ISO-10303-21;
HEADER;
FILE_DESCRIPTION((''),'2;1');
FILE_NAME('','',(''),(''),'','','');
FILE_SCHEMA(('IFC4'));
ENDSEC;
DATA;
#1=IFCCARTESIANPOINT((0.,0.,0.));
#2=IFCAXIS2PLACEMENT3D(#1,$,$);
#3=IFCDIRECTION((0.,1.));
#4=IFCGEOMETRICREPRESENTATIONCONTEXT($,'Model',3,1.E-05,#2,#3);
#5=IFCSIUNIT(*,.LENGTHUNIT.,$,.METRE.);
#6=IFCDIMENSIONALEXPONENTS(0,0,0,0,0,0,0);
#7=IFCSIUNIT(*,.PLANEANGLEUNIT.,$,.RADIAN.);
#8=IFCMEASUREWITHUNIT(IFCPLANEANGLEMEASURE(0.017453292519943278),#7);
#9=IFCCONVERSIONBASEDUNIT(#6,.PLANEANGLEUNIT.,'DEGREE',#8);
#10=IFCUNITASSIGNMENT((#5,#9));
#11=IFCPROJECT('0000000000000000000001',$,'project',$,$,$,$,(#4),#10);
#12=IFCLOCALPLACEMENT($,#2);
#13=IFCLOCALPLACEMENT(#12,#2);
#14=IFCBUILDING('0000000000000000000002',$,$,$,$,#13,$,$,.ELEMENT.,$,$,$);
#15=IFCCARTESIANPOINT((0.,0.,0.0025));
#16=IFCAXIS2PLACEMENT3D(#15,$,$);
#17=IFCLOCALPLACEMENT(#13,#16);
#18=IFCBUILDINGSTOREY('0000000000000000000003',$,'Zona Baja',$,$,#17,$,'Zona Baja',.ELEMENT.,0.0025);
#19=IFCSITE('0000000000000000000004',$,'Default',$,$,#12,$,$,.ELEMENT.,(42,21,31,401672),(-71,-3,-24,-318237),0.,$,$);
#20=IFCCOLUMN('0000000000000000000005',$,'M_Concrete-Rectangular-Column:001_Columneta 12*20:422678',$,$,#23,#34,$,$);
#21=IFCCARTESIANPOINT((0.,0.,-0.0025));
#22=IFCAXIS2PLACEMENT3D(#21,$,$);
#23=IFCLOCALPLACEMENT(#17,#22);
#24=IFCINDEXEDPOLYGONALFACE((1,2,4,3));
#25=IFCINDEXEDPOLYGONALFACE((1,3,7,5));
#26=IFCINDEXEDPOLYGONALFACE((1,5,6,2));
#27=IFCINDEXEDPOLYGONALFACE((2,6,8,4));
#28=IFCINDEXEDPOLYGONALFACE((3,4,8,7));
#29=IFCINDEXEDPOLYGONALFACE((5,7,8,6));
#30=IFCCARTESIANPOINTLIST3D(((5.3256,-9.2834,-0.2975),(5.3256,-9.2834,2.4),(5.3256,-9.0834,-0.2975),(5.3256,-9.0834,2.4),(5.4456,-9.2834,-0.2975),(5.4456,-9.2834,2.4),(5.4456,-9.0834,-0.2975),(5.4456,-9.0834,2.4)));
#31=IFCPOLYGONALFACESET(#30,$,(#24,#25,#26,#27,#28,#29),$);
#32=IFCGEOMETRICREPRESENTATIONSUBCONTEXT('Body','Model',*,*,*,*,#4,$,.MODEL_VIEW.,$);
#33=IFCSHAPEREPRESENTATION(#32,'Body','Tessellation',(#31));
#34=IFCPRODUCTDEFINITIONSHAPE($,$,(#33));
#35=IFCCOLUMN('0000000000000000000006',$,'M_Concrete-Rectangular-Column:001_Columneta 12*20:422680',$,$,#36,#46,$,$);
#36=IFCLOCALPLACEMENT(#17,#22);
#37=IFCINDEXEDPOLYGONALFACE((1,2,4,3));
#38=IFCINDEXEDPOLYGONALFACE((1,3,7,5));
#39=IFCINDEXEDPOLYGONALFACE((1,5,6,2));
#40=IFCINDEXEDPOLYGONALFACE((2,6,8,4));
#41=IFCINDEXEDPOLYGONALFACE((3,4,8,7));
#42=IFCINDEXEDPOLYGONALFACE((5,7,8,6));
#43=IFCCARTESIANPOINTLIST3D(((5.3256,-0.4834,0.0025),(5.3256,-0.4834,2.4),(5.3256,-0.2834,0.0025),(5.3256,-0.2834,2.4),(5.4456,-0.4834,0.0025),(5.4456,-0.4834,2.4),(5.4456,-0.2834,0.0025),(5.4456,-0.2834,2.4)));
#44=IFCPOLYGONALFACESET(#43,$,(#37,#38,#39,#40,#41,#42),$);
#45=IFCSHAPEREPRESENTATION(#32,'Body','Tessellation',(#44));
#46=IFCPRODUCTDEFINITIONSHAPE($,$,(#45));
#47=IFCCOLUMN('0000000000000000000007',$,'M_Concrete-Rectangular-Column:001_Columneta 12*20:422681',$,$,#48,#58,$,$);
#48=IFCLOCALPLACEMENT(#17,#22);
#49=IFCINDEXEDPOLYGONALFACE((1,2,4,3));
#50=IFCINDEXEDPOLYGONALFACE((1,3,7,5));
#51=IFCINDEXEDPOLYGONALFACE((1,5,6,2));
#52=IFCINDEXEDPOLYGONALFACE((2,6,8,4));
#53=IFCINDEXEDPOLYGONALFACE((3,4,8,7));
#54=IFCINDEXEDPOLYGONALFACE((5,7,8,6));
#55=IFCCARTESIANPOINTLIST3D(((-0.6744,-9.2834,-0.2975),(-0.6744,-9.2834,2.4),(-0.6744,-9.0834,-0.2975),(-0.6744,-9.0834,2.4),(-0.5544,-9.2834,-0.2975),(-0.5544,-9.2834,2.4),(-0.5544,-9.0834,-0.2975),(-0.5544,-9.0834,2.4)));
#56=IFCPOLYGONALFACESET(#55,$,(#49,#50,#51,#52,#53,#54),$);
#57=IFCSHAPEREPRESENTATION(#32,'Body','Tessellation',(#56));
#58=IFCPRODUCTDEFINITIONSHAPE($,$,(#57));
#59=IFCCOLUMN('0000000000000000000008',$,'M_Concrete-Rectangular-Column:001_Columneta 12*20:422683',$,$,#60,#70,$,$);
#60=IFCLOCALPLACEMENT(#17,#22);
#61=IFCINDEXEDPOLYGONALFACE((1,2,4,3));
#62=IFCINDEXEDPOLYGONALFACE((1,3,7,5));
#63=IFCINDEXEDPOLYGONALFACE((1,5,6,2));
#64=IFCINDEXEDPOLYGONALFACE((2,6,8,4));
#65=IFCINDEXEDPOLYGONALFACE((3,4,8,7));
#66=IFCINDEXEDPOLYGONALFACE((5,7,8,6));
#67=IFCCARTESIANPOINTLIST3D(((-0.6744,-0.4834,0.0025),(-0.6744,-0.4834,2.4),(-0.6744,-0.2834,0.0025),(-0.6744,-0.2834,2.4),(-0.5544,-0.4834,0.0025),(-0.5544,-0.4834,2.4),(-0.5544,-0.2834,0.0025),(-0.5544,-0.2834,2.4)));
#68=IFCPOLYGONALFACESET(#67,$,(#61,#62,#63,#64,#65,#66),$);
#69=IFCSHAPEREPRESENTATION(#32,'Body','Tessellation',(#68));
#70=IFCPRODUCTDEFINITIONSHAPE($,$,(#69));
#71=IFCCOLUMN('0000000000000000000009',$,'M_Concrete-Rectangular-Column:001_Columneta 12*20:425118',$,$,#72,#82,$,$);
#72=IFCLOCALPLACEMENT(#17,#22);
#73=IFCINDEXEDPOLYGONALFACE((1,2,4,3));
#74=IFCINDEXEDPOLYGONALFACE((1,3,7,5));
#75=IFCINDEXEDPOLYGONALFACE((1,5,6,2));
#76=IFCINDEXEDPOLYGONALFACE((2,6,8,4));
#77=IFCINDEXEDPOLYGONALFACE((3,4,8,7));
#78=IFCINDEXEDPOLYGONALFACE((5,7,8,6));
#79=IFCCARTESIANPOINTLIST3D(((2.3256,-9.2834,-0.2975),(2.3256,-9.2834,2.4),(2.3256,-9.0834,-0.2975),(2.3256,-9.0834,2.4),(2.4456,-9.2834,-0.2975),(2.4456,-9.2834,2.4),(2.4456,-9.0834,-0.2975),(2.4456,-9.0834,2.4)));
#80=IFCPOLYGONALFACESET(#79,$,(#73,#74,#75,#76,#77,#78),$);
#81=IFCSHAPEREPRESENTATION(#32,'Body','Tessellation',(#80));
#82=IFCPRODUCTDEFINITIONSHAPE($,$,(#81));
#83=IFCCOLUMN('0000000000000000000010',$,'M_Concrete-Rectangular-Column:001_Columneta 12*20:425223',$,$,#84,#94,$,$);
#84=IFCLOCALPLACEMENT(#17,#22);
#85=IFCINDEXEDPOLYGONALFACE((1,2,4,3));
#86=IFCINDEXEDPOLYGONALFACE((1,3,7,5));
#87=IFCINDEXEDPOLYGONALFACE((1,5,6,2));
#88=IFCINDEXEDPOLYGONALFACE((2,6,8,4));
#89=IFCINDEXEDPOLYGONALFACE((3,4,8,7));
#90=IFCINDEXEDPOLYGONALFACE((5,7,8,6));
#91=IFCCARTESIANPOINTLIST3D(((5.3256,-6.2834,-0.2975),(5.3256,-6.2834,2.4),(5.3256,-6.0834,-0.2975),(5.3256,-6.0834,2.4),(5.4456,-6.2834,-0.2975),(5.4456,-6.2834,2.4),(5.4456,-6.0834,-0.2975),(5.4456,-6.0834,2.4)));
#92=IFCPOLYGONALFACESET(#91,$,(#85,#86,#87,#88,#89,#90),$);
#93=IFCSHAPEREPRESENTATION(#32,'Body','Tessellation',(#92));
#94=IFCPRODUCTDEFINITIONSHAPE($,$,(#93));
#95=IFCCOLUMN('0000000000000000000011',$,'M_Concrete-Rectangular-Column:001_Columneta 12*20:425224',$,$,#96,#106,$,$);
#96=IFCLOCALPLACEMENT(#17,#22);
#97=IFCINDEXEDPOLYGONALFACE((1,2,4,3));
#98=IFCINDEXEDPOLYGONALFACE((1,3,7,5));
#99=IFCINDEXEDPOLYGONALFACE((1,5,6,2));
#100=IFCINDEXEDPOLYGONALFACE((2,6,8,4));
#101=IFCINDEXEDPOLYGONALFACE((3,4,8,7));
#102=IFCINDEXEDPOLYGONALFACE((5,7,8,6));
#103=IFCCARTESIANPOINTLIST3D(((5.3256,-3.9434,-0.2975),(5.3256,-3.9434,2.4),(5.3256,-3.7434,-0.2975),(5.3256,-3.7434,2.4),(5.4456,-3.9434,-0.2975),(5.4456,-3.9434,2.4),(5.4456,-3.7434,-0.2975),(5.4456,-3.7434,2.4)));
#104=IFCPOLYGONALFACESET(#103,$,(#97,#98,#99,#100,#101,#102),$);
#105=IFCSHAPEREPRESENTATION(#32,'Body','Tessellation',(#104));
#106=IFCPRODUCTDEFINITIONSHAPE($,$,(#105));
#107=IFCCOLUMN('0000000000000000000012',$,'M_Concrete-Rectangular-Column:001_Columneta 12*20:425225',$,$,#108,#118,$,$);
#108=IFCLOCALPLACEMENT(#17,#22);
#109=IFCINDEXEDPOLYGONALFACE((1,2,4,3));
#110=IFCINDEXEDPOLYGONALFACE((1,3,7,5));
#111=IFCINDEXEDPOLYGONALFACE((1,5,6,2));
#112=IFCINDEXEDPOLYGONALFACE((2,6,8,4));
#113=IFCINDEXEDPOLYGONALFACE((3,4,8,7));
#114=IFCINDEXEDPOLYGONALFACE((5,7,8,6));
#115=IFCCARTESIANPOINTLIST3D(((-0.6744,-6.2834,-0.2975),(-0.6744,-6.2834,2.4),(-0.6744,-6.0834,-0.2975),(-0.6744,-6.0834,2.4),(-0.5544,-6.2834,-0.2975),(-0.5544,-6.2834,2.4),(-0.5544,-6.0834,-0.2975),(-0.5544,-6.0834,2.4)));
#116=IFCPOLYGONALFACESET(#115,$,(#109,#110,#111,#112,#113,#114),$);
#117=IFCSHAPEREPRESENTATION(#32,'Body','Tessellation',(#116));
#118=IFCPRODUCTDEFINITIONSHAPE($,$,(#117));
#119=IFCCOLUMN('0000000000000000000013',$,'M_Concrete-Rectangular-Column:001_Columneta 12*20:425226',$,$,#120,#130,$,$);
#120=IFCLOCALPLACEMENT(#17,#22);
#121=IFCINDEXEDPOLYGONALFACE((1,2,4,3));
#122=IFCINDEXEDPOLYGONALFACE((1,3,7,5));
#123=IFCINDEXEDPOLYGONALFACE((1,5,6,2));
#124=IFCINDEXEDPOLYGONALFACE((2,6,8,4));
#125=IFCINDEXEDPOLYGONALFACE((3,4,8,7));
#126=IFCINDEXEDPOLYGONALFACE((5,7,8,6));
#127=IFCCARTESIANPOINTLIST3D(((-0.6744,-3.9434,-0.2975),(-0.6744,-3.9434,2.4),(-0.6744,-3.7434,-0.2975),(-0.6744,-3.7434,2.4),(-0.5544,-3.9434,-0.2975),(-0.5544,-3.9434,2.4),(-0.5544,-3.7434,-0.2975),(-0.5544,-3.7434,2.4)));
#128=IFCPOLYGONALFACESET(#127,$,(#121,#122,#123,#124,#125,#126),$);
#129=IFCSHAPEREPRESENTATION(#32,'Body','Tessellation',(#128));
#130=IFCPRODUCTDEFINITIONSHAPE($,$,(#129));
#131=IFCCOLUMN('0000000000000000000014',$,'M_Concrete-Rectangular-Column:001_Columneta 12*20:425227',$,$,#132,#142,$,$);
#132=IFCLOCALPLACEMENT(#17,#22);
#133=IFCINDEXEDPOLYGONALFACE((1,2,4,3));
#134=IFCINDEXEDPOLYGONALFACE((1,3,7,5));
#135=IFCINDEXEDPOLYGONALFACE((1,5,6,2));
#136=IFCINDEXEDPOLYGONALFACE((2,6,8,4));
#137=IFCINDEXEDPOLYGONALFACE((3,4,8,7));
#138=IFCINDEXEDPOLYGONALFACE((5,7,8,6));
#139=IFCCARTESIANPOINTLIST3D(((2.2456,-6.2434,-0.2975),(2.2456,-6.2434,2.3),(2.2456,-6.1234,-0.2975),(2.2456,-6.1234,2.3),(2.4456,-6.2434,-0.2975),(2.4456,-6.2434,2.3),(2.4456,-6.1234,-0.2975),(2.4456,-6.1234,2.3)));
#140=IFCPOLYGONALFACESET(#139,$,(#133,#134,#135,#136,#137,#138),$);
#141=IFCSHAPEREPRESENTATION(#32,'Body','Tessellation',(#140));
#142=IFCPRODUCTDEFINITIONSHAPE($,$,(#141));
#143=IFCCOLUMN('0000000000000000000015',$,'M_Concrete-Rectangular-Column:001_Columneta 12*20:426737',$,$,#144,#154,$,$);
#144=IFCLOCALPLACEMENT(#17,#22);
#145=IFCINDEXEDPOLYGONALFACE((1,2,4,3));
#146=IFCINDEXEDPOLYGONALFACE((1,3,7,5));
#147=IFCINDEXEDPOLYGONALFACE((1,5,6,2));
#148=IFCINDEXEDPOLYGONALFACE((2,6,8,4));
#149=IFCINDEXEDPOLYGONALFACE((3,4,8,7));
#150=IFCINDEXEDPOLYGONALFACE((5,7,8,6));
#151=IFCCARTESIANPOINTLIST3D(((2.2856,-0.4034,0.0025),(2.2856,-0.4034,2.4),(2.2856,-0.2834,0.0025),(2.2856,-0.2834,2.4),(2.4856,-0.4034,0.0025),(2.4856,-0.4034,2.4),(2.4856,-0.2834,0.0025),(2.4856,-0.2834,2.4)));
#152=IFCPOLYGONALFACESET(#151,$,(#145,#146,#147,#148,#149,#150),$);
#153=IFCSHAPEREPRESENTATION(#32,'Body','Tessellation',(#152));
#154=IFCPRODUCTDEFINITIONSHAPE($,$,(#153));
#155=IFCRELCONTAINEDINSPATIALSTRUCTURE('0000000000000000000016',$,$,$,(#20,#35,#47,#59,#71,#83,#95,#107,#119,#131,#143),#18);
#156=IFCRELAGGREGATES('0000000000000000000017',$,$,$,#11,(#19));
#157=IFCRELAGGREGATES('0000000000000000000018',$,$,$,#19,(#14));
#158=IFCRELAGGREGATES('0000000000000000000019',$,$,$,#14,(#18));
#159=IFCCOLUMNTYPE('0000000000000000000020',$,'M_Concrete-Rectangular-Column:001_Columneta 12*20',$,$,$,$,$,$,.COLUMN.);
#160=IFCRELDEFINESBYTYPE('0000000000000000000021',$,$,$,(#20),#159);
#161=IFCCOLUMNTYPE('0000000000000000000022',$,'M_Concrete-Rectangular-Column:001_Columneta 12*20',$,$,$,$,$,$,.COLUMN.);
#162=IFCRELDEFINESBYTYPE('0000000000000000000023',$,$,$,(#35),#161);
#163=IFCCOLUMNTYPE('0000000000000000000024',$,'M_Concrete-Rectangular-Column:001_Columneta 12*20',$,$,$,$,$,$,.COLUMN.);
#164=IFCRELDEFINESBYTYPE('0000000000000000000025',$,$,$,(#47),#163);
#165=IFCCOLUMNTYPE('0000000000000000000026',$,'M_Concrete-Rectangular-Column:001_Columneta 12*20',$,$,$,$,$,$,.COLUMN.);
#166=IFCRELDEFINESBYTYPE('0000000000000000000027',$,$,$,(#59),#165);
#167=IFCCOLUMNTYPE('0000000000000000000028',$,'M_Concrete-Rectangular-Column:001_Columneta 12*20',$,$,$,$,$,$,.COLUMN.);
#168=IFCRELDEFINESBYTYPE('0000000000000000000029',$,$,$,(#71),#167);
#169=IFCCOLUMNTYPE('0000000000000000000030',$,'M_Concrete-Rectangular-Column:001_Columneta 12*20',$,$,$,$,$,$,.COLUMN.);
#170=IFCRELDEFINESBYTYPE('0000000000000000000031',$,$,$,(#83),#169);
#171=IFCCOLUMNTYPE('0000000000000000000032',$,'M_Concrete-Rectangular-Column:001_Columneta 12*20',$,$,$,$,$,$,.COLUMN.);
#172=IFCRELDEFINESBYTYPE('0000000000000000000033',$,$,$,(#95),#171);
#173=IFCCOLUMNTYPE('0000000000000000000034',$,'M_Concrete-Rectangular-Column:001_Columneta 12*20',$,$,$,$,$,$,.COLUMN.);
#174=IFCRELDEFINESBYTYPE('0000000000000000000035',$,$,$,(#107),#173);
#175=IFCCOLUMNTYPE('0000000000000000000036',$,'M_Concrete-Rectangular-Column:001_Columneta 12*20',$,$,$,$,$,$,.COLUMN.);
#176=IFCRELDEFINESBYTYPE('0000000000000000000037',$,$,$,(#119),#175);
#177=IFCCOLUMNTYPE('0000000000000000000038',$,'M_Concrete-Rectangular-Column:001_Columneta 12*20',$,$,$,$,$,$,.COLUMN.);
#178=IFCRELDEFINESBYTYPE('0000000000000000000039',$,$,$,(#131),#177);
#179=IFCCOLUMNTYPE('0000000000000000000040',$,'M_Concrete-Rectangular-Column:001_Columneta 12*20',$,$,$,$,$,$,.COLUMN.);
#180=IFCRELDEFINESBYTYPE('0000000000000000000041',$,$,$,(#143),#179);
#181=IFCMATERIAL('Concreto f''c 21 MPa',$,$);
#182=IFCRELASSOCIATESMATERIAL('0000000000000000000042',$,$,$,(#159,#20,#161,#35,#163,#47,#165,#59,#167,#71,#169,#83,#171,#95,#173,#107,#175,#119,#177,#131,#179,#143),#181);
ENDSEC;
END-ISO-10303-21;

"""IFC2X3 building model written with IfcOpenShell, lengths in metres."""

from ifc_helpers import new_model, entity, si_unit, converted_unit, direction, frame, frame_2d, origin, origin_2d_with_axis, place, context, subcontext, project, spatial, rectangle, extrude, source, transform, mapped, material, type_object, type_shapes, element, save


model = new_model("IFC2X3")

# Units and contexts
model_context = context("Model", 3, precision=1e-05, world=origin(), true_north=direction((0.0, 1.0)))
body_context = subcontext(model_context, "Body", "Model", "MODEL_VIEW")
ifc_project = project(units=[si_unit("LENGTHUNIT", "METRE"), converted_unit("PLANEANGLEUNIT", "DEGREE", entity("IfcPlaneAngleMeasure", 0.017453292519943278), si_unit("PLANEANGLEUNIT", "RADIAN"), dimensions=[0, 0, 0, 0, 0, 0, 0])], contexts=[model_context])

# Site, building, storey
site_placement = place(None, origin())
site = spatial("IfcSite", under=ifc_project, at=site_placement, Name="Default", CompositionType="ELEMENT", RefLatitude=(42, 21, 31, 401672), RefLongitude=(-71, -3, -24, -318237), RefElevation=0.0)
building_placement = place(site_placement, origin())
building = spatial("IfcBuilding", under=site, at=building_placement, CompositionType="ELEMENT")
storey_placement = place(building_placement, frame((0.0, 0.0, 0.0025)))
storey = spatial("IfcBuildingStorey", under=building, at=storey_placement, Name="Zona Baja", LongName="Zona Baja", CompositionType="ELEMENT", Elevation=0.0025)

# Columns
ifc_material_1 = material(Name="Concreto f'c 21 MPa")
column_type_1 = type_object("IfcColumnType", Name="M_Concrete-Rectangular-Column:001_Columneta 12*20", PredefinedType="COLUMN", material=ifc_material_1)
shared_shape_1 = source(origin(), body_context, "Body", "SweptSolid", [
    extrude(rectangle(XDim=0.12, YDim=0.2, at=frame_2d((0.0, 0.0), x_axis=(1.0, 0.0))), frame((5.3856, -9.1834, -0.2975), z_axis=(0.0, 0.0, 1.0), x_axis=(-1.0, 0.0, 0.0)), (0.0, 0.0, 1.0), 2.6975),
])
type_shapes(column_type_1, [shared_shape_1])
column_1_placement = place(storey_placement, frame((0.0, 0.0, -0.0025)))
element("IfcColumn", 1, at=column_1_placement, inside=storey, type_object=column_type_1, material=ifc_material_1, Name="M_Concrete-Rectangular-Column:001_Columneta 12*20:422678", context=body_context, shape_type="MappedRepresentation", body=[
    mapped(shared_shape_1, transform((0.0, 0.0, 0.0), scale=1.0)),
])
column_type_2 = type_object("IfcColumnType", Name="M_Concrete-Rectangular-Column:001_Columneta 12*20", PredefinedType="COLUMN", material=ifc_material_1)
shared_shape_2 = source(origin(), body_context, "Body", "SweptSolid", [
    extrude(rectangle(XDim=0.12, YDim=0.2, at=frame_2d((0.0, 0.0), x_axis=(1.0, 0.0))), frame((5.3856, -0.3834, 0.0025), z_axis=(0.0, 0.0, 1.0), x_axis=(-1.0, 0.0, 0.0)), (0.0, 0.0, 1.0), 2.3975),
])
type_shapes(column_type_2, [shared_shape_2])
column_2_placement = place(storey_placement, frame((0.0, 0.0, -0.0025)))
element("IfcColumn", 2, at=column_2_placement, inside=storey, type_object=column_type_2, material=ifc_material_1, Name="M_Concrete-Rectangular-Column:001_Columneta 12*20:422680", context=body_context, shape_type="MappedRepresentation", body=[
    mapped(shared_shape_2, transform((0.0, 0.0, 0.0), scale=1.0)),
])
column_type_3 = type_object("IfcColumnType", Name="M_Concrete-Rectangular-Column:001_Columneta 12*20", PredefinedType="COLUMN", material=ifc_material_1)
shared_shape_3 = source(origin(), body_context, "Body", "SweptSolid", [
    extrude(rectangle(XDim=0.12, YDim=0.2, at=origin_2d_with_axis()), frame((-0.6144, -9.1834, -0.2975), z_axis=(0.0, 0.0, 1.0), x_axis=(-1.0, 0.0, 0.0)), (0.0, 0.0, 1.0), 2.6975),
])
type_shapes(column_type_3, [shared_shape_3])
column_3_placement = place(storey_placement, frame((0.0, 0.0, -0.0025)))
element("IfcColumn", 3, at=column_3_placement, inside=storey, type_object=column_type_3, material=ifc_material_1, Name="M_Concrete-Rectangular-Column:001_Columneta 12*20:422681", context=body_context, shape_type="MappedRepresentation", body=[
    mapped(shared_shape_3, transform((0.0, 0.0, 0.0), scale=1.0)),
])
column_type_4 = type_object("IfcColumnType", Name="M_Concrete-Rectangular-Column:001_Columneta 12*20", PredefinedType="COLUMN", material=ifc_material_1)
shared_shape_4 = source(origin(), body_context, "Body", "SweptSolid", [
    extrude(rectangle(XDim=0.12, YDim=0.2, at=origin_2d_with_axis()), frame((-0.6144, -0.3834, 0.0025), z_axis=(0.0, 0.0, 1.0), x_axis=(-1.0, 0.0, 0.0)), (0.0, 0.0, 1.0), 2.3975),
])
type_shapes(column_type_4, [shared_shape_4])
column_4_placement = place(storey_placement, frame((0.0, 0.0, -0.0025)))
element("IfcColumn", 4, at=column_4_placement, inside=storey, type_object=column_type_4, material=ifc_material_1, Name="M_Concrete-Rectangular-Column:001_Columneta 12*20:422683", context=body_context, shape_type="MappedRepresentation", body=[
    mapped(shared_shape_4, transform((0.0, 0.0, 0.0), scale=1.0)),
])
column_type_5 = type_object("IfcColumnType", Name="M_Concrete-Rectangular-Column:001_Columneta 12*20", PredefinedType="COLUMN", material=ifc_material_1)
shared_shape_5 = source(origin(), body_context, "Body", "SweptSolid", [
    extrude(rectangle(XDim=0.12, YDim=0.2, at=frame_2d((0.0, 0.0), x_axis=(1.0, 0.0))), frame((2.3856, -9.1834, -0.2975), z_axis=(0.0, 0.0, 1.0), x_axis=(-1.0, 0.0, 0.0)), (0.0, 0.0, 1.0), 2.6975),
])
type_shapes(column_type_5, [shared_shape_5])
column_5_placement = place(storey_placement, frame((0.0, 0.0, -0.0025)))
element("IfcColumn", 5, at=column_5_placement, inside=storey, type_object=column_type_5, material=ifc_material_1, Name="M_Concrete-Rectangular-Column:001_Columneta 12*20:425118", context=body_context, shape_type="MappedRepresentation", body=[
    mapped(shared_shape_5, transform((0.0, 0.0, 0.0), scale=1.0)),
])
column_type_6 = type_object("IfcColumnType", Name="M_Concrete-Rectangular-Column:001_Columneta 12*20", PredefinedType="COLUMN", material=ifc_material_1)
shared_shape_6 = source(origin(), body_context, "Body", "SweptSolid", [
    extrude(rectangle(XDim=0.12, YDim=0.2, at=frame_2d((0.0, 0.0), x_axis=(1.0, 0.0))), frame((5.3856, -6.1834, -0.2975), z_axis=(0.0, 0.0, 1.0), x_axis=(-1.0, 0.0, 0.0)), (0.0, 0.0, 1.0), 2.6975),
])
type_shapes(column_type_6, [shared_shape_6])
column_6_placement = place(storey_placement, frame((0.0, 0.0, -0.0025)))
element("IfcColumn", 6, at=column_6_placement, inside=storey, type_object=column_type_6, material=ifc_material_1, Name="M_Concrete-Rectangular-Column:001_Columneta 12*20:425223", context=body_context, shape_type="MappedRepresentation", body=[
    mapped(shared_shape_6, transform((0.0, 0.0, 0.0), scale=1.0)),
])
column_type_7 = type_object("IfcColumnType", Name="M_Concrete-Rectangular-Column:001_Columneta 12*20", PredefinedType="COLUMN", material=ifc_material_1)
shared_shape_7 = source(origin(), body_context, "Body", "SweptSolid", [
    extrude(rectangle(XDim=0.12, YDim=0.2, at=frame_2d((0.0, 0.0), x_axis=(1.0, 0.0))), frame((5.3856, -3.8434, -0.2975), z_axis=(0.0, 0.0, 1.0), x_axis=(-1.0, 0.0, 0.0)), (0.0, 0.0, 1.0), 2.6975),
])
type_shapes(column_type_7, [shared_shape_7])
column_7_placement = place(storey_placement, frame((0.0, 0.0, -0.0025)))
element("IfcColumn", 7, at=column_7_placement, inside=storey, type_object=column_type_7, material=ifc_material_1, Name="M_Concrete-Rectangular-Column:001_Columneta 12*20:425224", context=body_context, shape_type="MappedRepresentation", body=[
    mapped(shared_shape_7, transform((0.0, 0.0, 0.0), scale=1.0)),
])
column_type_8 = type_object("IfcColumnType", Name="M_Concrete-Rectangular-Column:001_Columneta 12*20", PredefinedType="COLUMN", material=ifc_material_1)
shared_shape_8 = source(origin(), body_context, "Body", "SweptSolid", [
    extrude(rectangle(XDim=0.12, YDim=0.2, at=frame_2d((0.0, 0.0), x_axis=(1.0, 0.0))), frame((-0.6144, -6.1834, -0.2975), z_axis=(0.0, 0.0, 1.0), x_axis=(-1.0, 0.0, 0.0)), (0.0, 0.0, 1.0), 2.6975),
])
type_shapes(column_type_8, [shared_shape_8])
column_8_placement = place(storey_placement, frame((0.0, 0.0, -0.0025)))
element("IfcColumn", 8, at=column_8_placement, inside=storey, type_object=column_type_8, material=ifc_material_1, Name="M_Concrete-Rectangular-Column:001_Columneta 12*20:425225", context=body_context, shape_type="MappedRepresentation", body=[
    mapped(shared_shape_8, transform((0.0, 0.0, 0.0), scale=1.0)),
])
column_type_9 = type_object("IfcColumnType", Name="M_Concrete-Rectangular-Column:001_Columneta 12*20", PredefinedType="COLUMN", material=ifc_material_1)
shared_shape_9 = source(origin(), body_context, "Body", "SweptSolid", [
    extrude(rectangle(XDim=0.12, YDim=0.2, at=frame_2d((0.0, 0.0), x_axis=(1.0, 0.0))), frame((-0.6144, -3.8434, -0.2975), z_axis=(0.0, 0.0, 1.0), x_axis=(-1.0, 0.0, 0.0)), (0.0, 0.0, 1.0), 2.6975),
])
type_shapes(column_type_9, [shared_shape_9])
column_9_placement = place(storey_placement, frame((0.0, 0.0, -0.0025)))
element("IfcColumn", 9, at=column_9_placement, inside=storey, type_object=column_type_9, material=ifc_material_1, Name="M_Concrete-Rectangular-Column:001_Columneta 12*20:425226", context=body_context, shape_type="MappedRepresentation", body=[
    mapped(shared_shape_9, transform((0.0, 0.0, 0.0), scale=1.0)),
])
column_type_10 = type_object("IfcColumnType", Name="M_Concrete-Rectangular-Column:001_Columneta 12*20", PredefinedType="COLUMN", material=ifc_material_1)
shared_shape_10 = source(origin(), body_context, "Body", "SweptSolid", [
    extrude(rectangle(XDim=0.12, YDim=0.2, at=frame_2d((0.0, 0.0), x_axis=(1.0, 0.0))), frame((2.3456, -6.1834, -0.2975), z_axis=(0.0, 0.0, 1.0), x_axis=(0.0, 1.0, 0.0)), (0.0, 0.0, 1.0), 2.5975),
])
type_shapes(column_type_10, [shared_shape_10])
column_10_placement = place(storey_placement, frame((0.0, 0.0, -0.0025)))
element("IfcColumn", 10, at=column_10_placement, inside=storey, type_object=column_type_10, material=ifc_material_1, Name="M_Concrete-Rectangular-Column:001_Columneta 12*20:425227", context=body_context, shape_type="MappedRepresentation", body=[
    mapped(shared_shape_10, transform((0.0, 0.0, 0.0), scale=1.0)),
])
column_type_11 = type_object("IfcColumnType", Name="M_Concrete-Rectangular-Column:001_Columneta 12*20", PredefinedType="COLUMN", material=ifc_material_1)
shared_shape_11 = source(origin(), body_context, "Body", "SweptSolid", [
    extrude(rectangle(XDim=0.12, YDim=0.2, at=frame_2d((0.0, 0.0), x_axis=(1.0, 0.0))), frame((2.3856, -0.3434, 0.0025), z_axis=(0.0, 0.0, 1.0), x_axis=(0.0, -1.0, 0.0)), (0.0, 0.0, 1.0), 2.3975),
])
type_shapes(column_type_11, [shared_shape_11])
column_11_placement = place(storey_placement, frame((0.0, 0.0, -0.0025)))
element("IfcColumn", 11, at=column_11_placement, inside=storey, type_object=column_type_11, material=ifc_material_1, Name="M_Concrete-Rectangular-Column:001_Columneta 12*20:426737", context=body_context, shape_type="MappedRepresentation", body=[
    mapped(shared_shape_11, transform((0.0, 0.0, 0.0), scale=1.0)),
])

save(model, "model.ifc")
